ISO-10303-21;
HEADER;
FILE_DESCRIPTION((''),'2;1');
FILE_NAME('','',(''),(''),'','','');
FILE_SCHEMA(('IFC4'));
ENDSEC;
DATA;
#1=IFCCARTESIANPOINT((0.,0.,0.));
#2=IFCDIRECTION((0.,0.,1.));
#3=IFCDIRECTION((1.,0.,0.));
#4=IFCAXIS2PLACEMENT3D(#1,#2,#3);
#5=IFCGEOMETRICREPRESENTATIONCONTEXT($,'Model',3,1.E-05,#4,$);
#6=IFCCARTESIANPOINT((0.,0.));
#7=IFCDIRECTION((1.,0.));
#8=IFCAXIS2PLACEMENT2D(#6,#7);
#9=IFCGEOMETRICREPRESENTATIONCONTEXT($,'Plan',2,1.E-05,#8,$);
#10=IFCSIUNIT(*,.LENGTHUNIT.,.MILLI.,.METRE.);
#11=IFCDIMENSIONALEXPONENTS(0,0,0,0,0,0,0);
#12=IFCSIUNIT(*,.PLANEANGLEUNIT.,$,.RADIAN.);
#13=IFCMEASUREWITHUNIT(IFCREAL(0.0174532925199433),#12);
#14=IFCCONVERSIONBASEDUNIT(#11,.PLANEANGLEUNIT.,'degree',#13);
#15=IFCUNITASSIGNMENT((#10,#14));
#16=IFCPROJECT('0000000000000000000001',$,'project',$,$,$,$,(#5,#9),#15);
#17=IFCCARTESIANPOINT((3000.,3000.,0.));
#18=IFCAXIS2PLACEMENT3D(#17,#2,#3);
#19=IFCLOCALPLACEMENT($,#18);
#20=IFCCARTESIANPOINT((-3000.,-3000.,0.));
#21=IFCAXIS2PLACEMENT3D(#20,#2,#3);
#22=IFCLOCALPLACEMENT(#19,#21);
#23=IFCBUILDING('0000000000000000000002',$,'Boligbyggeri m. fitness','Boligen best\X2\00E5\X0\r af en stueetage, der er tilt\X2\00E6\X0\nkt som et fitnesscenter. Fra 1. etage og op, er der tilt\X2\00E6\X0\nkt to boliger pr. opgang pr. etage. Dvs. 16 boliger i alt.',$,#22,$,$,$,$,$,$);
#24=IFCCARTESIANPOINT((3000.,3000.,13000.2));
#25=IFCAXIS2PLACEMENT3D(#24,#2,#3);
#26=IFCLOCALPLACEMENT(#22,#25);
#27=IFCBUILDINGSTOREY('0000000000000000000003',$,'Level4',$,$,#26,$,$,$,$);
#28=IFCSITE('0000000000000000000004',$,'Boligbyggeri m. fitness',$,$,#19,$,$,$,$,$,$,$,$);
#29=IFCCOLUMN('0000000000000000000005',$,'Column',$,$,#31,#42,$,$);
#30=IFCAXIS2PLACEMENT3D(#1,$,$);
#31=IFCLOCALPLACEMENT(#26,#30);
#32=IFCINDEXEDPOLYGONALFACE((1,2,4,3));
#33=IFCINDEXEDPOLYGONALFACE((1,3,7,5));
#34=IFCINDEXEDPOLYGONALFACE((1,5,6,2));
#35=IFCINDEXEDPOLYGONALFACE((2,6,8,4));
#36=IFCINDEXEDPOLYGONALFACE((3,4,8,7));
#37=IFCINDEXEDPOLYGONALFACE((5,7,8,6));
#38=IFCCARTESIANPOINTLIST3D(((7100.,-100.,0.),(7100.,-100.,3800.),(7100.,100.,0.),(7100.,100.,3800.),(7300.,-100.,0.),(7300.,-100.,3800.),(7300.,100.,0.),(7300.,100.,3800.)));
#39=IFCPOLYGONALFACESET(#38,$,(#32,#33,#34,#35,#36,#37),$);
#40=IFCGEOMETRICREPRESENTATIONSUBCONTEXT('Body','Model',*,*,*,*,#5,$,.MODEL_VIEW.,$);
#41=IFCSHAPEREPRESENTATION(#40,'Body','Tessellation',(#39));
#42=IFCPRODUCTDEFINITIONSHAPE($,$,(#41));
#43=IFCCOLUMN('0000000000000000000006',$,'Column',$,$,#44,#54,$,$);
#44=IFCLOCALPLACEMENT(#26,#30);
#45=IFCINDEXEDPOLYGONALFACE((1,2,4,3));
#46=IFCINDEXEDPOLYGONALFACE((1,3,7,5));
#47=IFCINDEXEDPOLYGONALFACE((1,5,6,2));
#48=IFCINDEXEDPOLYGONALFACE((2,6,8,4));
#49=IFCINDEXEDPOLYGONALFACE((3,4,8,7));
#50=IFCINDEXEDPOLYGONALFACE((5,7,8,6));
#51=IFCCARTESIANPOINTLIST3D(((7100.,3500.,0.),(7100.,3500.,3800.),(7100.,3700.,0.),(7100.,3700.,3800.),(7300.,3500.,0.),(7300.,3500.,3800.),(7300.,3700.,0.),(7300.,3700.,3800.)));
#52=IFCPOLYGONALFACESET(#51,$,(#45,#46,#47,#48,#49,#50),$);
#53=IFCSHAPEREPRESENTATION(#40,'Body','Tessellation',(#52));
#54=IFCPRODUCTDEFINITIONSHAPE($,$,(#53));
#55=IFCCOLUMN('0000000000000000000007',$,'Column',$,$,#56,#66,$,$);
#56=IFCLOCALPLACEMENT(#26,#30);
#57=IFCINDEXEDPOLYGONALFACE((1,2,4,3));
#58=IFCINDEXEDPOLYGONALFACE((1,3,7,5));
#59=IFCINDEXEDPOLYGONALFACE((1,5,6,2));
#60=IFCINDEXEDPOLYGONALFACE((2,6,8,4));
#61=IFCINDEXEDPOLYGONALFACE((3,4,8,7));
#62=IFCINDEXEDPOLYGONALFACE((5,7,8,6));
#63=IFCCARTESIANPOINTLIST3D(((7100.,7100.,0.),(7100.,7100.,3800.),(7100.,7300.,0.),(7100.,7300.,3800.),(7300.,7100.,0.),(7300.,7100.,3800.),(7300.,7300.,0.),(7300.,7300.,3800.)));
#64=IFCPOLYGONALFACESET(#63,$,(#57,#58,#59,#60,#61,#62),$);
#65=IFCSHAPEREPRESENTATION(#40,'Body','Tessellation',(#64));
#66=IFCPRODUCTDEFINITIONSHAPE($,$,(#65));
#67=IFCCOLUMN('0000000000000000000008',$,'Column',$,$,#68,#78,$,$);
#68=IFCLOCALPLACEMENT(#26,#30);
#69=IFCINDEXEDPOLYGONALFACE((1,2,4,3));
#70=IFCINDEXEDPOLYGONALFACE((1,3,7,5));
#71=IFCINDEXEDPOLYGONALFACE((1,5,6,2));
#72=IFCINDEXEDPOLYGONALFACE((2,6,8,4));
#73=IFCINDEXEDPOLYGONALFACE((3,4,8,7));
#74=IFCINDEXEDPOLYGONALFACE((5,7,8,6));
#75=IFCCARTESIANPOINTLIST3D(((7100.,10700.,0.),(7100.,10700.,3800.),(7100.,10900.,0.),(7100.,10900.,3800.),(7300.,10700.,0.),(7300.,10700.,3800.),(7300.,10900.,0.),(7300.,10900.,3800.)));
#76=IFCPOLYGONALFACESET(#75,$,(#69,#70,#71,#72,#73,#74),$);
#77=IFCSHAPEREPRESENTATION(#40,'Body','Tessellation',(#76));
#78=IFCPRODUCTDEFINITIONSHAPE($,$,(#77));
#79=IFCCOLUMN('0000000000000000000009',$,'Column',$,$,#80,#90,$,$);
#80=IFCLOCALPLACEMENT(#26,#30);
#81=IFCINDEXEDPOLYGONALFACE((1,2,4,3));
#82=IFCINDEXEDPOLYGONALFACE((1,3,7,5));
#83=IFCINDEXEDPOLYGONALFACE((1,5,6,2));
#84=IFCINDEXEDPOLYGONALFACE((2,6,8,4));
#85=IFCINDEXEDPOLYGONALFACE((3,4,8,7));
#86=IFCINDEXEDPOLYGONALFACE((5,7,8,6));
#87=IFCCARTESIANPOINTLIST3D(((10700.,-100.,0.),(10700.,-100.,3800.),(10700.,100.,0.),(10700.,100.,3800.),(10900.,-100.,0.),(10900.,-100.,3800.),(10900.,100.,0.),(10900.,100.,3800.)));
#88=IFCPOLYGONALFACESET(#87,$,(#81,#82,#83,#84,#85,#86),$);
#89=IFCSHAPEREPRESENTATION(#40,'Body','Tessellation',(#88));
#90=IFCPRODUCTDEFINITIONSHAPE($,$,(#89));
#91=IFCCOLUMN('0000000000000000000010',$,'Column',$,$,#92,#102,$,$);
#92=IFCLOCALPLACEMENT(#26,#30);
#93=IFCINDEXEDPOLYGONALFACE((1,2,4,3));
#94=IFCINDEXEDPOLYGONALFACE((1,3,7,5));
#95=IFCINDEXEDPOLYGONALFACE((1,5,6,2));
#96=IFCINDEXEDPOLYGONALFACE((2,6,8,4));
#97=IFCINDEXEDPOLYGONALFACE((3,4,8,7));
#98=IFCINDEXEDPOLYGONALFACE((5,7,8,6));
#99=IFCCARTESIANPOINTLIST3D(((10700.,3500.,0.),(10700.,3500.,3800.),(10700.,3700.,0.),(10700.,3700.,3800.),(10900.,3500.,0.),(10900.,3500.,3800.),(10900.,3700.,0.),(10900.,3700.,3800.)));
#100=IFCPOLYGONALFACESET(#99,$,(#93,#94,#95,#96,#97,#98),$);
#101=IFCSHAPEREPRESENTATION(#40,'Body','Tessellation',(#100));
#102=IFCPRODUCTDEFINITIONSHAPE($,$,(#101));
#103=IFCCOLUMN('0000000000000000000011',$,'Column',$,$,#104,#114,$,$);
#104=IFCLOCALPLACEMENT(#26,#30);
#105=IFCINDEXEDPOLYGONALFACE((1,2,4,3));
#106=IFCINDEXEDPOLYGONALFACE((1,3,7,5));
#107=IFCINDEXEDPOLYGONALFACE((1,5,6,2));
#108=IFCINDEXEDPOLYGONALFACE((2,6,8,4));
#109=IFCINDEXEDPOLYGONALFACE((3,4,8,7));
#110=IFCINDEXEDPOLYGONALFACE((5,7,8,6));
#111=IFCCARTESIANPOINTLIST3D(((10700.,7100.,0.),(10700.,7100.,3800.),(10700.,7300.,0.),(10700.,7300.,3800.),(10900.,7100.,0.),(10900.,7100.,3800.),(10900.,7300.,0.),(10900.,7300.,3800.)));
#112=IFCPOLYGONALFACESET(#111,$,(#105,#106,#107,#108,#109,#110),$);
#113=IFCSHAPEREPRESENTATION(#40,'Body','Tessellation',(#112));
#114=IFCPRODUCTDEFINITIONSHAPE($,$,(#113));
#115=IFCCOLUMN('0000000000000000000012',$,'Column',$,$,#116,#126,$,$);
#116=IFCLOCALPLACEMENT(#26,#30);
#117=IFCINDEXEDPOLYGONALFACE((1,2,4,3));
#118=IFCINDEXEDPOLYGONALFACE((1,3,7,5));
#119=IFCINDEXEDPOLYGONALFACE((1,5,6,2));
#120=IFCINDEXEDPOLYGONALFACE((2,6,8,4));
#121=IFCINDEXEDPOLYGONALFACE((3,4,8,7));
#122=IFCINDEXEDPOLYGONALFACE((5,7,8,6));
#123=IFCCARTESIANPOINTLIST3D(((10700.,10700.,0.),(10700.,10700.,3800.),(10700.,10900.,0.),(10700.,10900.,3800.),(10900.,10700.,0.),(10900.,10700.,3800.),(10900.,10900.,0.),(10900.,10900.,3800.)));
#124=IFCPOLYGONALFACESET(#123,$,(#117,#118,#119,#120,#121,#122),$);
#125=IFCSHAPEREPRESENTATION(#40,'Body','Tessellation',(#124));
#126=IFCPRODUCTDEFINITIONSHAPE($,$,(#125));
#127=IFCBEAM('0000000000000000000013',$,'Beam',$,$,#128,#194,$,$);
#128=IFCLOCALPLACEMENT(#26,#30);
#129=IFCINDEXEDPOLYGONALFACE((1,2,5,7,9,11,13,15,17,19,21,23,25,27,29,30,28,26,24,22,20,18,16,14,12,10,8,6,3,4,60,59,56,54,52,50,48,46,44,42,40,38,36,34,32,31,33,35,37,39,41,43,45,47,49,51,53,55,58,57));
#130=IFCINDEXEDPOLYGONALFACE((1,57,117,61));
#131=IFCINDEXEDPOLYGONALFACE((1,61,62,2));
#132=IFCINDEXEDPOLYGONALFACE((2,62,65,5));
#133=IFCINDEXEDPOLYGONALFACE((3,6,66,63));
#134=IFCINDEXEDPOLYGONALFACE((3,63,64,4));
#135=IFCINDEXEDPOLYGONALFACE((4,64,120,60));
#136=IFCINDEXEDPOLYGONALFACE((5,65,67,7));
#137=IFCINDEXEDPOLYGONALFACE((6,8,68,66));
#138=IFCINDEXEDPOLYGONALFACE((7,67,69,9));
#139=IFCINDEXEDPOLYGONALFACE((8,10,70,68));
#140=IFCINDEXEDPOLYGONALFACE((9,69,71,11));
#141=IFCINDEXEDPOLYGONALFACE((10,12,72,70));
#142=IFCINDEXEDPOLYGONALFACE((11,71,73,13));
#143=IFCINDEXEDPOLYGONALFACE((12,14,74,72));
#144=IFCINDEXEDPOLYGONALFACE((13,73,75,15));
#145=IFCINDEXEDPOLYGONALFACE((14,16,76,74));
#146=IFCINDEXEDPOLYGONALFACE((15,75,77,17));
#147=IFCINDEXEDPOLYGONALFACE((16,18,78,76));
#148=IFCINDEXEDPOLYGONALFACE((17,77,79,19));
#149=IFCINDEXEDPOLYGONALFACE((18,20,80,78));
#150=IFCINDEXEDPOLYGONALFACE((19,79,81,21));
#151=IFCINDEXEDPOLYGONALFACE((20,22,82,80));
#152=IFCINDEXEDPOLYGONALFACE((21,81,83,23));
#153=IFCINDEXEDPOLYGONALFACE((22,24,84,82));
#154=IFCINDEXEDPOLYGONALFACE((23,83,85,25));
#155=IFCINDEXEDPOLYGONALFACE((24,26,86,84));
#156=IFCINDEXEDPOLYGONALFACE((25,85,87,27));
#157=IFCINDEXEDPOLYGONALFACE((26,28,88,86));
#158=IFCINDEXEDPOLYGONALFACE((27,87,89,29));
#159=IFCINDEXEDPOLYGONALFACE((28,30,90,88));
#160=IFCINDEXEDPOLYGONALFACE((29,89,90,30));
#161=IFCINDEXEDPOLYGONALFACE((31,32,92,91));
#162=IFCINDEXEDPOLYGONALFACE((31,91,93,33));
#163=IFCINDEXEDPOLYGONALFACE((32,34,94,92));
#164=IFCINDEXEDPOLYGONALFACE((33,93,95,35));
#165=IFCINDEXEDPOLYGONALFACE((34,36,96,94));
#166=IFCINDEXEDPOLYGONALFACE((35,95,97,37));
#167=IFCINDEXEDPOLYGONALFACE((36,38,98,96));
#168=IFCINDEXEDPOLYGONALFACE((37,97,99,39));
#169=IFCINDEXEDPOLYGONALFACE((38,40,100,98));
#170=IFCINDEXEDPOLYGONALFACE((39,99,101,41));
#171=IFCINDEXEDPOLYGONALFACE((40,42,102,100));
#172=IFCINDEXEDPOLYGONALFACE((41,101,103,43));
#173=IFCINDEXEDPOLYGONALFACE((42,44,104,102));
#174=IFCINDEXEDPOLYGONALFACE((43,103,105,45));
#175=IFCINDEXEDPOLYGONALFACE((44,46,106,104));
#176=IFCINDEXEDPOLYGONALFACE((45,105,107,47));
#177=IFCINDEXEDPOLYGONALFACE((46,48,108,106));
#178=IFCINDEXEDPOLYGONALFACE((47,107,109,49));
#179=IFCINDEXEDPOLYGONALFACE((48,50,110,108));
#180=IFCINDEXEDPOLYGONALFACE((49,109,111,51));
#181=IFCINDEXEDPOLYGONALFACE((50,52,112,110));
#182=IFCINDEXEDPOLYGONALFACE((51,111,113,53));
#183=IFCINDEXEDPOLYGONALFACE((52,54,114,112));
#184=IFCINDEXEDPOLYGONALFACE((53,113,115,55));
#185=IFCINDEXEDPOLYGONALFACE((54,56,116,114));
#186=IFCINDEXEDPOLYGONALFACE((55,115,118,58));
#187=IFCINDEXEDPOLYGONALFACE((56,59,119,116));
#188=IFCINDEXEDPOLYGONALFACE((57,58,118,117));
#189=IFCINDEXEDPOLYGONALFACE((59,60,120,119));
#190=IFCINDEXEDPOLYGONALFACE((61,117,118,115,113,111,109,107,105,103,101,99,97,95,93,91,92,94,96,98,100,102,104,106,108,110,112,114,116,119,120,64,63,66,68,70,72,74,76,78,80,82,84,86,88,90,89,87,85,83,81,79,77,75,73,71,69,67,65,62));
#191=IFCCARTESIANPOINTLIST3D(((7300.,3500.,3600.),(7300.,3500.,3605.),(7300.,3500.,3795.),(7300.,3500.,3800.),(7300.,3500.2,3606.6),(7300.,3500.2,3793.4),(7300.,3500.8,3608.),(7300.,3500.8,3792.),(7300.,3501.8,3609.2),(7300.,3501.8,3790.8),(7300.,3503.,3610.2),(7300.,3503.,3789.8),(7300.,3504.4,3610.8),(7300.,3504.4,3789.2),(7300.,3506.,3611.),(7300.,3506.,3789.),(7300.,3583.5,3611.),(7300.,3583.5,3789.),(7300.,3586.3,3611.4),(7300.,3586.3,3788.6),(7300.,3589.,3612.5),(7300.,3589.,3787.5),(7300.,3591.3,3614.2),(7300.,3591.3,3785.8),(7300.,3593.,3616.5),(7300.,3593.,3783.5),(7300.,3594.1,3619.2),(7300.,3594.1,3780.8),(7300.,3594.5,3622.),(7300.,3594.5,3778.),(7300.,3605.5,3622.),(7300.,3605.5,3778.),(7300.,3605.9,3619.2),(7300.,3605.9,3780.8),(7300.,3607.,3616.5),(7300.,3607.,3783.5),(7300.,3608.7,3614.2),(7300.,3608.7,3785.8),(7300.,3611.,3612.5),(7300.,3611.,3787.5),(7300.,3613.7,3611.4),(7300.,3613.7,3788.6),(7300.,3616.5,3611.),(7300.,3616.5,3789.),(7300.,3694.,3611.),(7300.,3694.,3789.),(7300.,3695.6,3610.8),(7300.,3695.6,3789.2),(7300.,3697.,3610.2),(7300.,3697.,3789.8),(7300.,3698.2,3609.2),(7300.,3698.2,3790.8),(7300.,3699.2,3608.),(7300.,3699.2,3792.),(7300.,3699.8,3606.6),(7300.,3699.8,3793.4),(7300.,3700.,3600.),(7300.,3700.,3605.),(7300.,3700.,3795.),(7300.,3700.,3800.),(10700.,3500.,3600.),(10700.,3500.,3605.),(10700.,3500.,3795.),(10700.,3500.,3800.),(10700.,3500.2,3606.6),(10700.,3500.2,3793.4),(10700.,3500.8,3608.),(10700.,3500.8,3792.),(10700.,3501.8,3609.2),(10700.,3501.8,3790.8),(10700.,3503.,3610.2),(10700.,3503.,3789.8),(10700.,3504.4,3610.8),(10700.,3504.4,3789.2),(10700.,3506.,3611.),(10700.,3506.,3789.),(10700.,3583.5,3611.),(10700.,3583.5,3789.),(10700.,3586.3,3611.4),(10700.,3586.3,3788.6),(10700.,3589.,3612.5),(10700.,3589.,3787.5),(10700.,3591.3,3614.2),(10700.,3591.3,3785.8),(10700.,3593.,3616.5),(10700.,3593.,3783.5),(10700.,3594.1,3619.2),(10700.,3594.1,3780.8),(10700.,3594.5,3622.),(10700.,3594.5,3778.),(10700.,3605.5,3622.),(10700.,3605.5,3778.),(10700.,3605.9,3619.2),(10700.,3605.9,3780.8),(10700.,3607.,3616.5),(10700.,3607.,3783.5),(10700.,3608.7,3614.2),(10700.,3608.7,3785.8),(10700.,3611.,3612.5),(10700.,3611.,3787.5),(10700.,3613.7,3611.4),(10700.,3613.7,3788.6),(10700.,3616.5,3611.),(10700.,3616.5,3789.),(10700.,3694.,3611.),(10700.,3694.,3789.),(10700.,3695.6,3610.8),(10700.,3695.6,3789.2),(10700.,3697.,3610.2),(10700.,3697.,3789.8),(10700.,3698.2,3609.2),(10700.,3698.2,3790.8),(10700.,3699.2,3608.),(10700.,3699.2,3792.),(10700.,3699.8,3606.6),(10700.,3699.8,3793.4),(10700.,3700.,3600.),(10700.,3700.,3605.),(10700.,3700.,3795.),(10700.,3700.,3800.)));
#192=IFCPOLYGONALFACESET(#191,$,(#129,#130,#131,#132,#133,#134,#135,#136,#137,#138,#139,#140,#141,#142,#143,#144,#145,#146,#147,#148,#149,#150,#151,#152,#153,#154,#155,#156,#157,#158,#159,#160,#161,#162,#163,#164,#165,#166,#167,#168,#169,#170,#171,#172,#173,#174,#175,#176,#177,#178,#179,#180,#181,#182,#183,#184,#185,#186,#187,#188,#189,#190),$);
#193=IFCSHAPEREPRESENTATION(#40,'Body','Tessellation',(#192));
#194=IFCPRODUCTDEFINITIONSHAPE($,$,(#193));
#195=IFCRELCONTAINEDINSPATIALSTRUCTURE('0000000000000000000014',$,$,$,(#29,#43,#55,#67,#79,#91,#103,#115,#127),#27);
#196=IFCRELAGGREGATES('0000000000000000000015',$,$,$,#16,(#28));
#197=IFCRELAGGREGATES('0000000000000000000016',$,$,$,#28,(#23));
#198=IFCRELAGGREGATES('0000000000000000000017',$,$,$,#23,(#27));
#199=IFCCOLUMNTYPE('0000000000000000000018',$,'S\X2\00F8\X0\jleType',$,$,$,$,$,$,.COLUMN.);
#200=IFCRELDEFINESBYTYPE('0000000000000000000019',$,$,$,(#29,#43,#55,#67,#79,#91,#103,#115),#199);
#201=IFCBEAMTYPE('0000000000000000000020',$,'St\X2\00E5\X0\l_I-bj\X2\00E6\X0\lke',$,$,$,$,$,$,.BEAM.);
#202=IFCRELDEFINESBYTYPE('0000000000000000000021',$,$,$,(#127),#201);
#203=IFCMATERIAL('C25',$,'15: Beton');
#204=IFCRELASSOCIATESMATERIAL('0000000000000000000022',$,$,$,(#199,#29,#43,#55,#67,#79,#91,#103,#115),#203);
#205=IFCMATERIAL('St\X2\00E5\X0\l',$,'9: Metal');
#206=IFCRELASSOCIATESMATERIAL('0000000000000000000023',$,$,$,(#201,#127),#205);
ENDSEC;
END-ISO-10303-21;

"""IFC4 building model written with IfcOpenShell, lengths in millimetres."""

from ifc_helpers import new_model, entity, si_unit, converted_unit, frame, origin_with_axes, origin_2d_with_axis, place, context, subcontext, project, spatial, rectangle, i_section, extrude, material, material_profile, profile_set, profile_usage, type_object, element, save


model = new_model("IFC4")

# Units and contexts
model_context = context("Model", 3, precision=1e-05, world=origin_with_axes())
plan_context = context("Plan", 2, precision=1e-05, world=origin_2d_with_axis())
body_context = subcontext(model_context, "Body", "Model", "MODEL_VIEW")
ifc_project = project(units=[si_unit("LENGTHUNIT", "METRE", prefix="MILLI"), converted_unit("PLANEANGLEUNIT", "degree", entity("IfcReal", 0.0174532925199433), si_unit("PLANEANGLEUNIT", "RADIAN"), dimensions=[0, 0, 0, 0, 0, 0, 0])], contexts=[model_context, plan_context])

# Site, building, storey
site_placement = place(None, frame((3000.0, 3000.0, 0.0), z_axis=(0.0, 0.0, 1.0), x_axis=(1.0, 0.0, 0.0)))
site = spatial("IfcSite", under=ifc_project, at=site_placement, Name="Boligbyggeri m. fitness")
building_placement = place(site_placement, frame((-3000.0, -3000.0, 0.0), z_axis=(0.0, 0.0, 1.0), x_axis=(1.0, 0.0, 0.0)))
building = spatial("IfcBuilding", under=site, at=building_placement, Name="Boligbyggeri m. fitness", Description="Boligen består af en stueetage, der er tiltænkt som et fitnesscenter. Fra 1. etage og op, er der tiltænkt to boliger pr. opgang pr. etage. Dvs. 16 boliger i alt.")
storey_placement = place(building_placement, frame((3000.0, 3000.0, 13000.2), z_axis=(0.0, 0.0, 1.0), x_axis=(1.0, 0.0, 0.0)))
storey = spatial("IfcBuildingStorey", under=building, at=storey_placement, Name="Level4")

# Columns
ifc_material_1 = material(Name="C25", Category="15: Beton")
ifc_material_profile_1 = material_profile(ifc_material_1, rectangle(XDim=200.0, YDim=200.0), Name="SøjleBeton", Category="15: Beton")
ifc_profile_set_1 = profile_set([ifc_material_profile_1], Name="200x200")
ifc_profile_usage_1 = profile_usage(ifc_profile_set_1, cardinal=5)
column_type = type_object("IfcColumnType", Name="SøjleType", PredefinedType="COLUMN", material=ifc_profile_set_1)
column_1_placement = place(storey_placement, frame((7200.0, 0.0, 0.0), z_axis=(0.0, 0.0, 1.0), x_axis=(1.0, 0.0, 0.0)))
element("IfcColumn", 1, at=column_1_placement, inside=storey, type_object=column_type, material=ifc_profile_usage_1, Name="Column", context=body_context, shape_type="SweptSolid", body=[
    extrude(rectangle(XDim=200.0, YDim=200.0), origin_with_axes(), (0.0, 0.0, 1.0), 3800.0),
])
ifc_profile_usage_2 = profile_usage(ifc_profile_set_1, cardinal=5)
column_2_placement = place(storey_placement, frame((7200.0, 3600.0, 0.0), z_axis=(0.0, 0.0, 1.0), x_axis=(1.0, 0.0, 0.0)))
element("IfcColumn", 2, at=column_2_placement, inside=storey, type_object=column_type, material=ifc_profile_usage_2, Name="Column", context=body_context, shape_type="SweptSolid", body=[
    extrude(rectangle(XDim=200.0, YDim=200.0), origin_with_axes(), (0.0, 0.0, 1.0), 3800.0),
])
ifc_profile_usage_3 = profile_usage(ifc_profile_set_1, cardinal=5)
column_3_placement = place(storey_placement, frame((7200.0, 7200.0, 0.0), z_axis=(0.0, 0.0, 1.0), x_axis=(1.0, 0.0, 0.0)))
element("IfcColumn", 3, at=column_3_placement, inside=storey, type_object=column_type, material=ifc_profile_usage_3, Name="Column", context=body_context, shape_type="SweptSolid", body=[
    extrude(rectangle(XDim=200.0, YDim=200.0), origin_with_axes(), (0.0, 0.0, 1.0), 3800.0),
])
ifc_profile_usage_4 = profile_usage(ifc_profile_set_1, cardinal=5)
column_4_placement = place(storey_placement, frame((7200.0, 10800.0, 0.0), z_axis=(0.0, 0.0, 1.0), x_axis=(1.0, 0.0, 0.0)))
element("IfcColumn", 4, at=column_4_placement, inside=storey, type_object=column_type, material=ifc_profile_usage_4, Name="Column", context=body_context, shape_type="SweptSolid", body=[
    extrude(rectangle(XDim=200.0, YDim=200.0), origin_with_axes(), (0.0, 0.0, 1.0), 3800.0),
])
ifc_profile_usage_5 = profile_usage(ifc_profile_set_1, cardinal=5)
column_5_placement = place(storey_placement, frame((10800.0, 0.0, 0.0), z_axis=(0.0, 0.0, 1.0), x_axis=(1.0, 0.0, 0.0)))
element("IfcColumn", 5, at=column_5_placement, inside=storey, type_object=column_type, material=ifc_profile_usage_5, Name="Column", context=body_context, shape_type="SweptSolid", body=[
    extrude(rectangle(XDim=200.0, YDim=200.0), origin_with_axes(), (0.0, 0.0, 1.0), 3800.0),
])
ifc_profile_usage_6 = profile_usage(ifc_profile_set_1, cardinal=5)
column_6_placement = place(storey_placement, frame((10800.0, 3600.0, 0.0), z_axis=(0.0, 0.0, 1.0), x_axis=(1.0, 0.0, 0.0)))
element("IfcColumn", 6, at=column_6_placement, inside=storey, type_object=column_type, material=ifc_profile_usage_6, Name="Column", context=body_context, shape_type="SweptSolid", body=[
    extrude(rectangle(XDim=200.0, YDim=200.0), origin_with_axes(), (0.0, 0.0, 1.0), 3800.0),
])
ifc_profile_usage_7 = profile_usage(ifc_profile_set_1, cardinal=5)
column_7_placement = place(storey_placement, frame((10800.0, 7200.0, 0.0), z_axis=(0.0, 0.0, 1.0), x_axis=(1.0, 0.0, 0.0)))
element("IfcColumn", 7, at=column_7_placement, inside=storey, type_object=column_type, material=ifc_profile_usage_7, Name="Column", context=body_context, shape_type="SweptSolid", body=[
    extrude(rectangle(XDim=200.0, YDim=200.0), origin_with_axes(), (0.0, 0.0, 1.0), 3800.0),
])
ifc_profile_usage_8 = profile_usage(ifc_profile_set_1, cardinal=5)
column_8_placement = place(storey_placement, frame((10800.0, 10800.0, 0.0), z_axis=(0.0, 0.0, 1.0), x_axis=(1.0, 0.0, 0.0)))
element("IfcColumn", 8, at=column_8_placement, inside=storey, type_object=column_type, material=ifc_profile_usage_8, Name="Column", context=body_context, shape_type="SweptSolid", body=[
    extrude(rectangle(XDim=200.0, YDim=200.0), origin_with_axes(), (0.0, 0.0, 1.0), 3800.0),
])

# Beam
ifc_material_2 = material(Name="Stål", Category="9: Metal")
ifc_material_profile_2 = material_profile(ifc_material_2, i_section(OverallWidth=200.0, OverallDepth=200.0, WebThickness=11.0, FlangeThickness=11.0, FilletRadius=11.0, FlangeEdgeRadius=6.0), Name="Stål", Category="9: Metal")
ifc_profile_set_2 = profile_set([ifc_material_profile_2], Name="NY_I-Profil")
ifc_profile_usage_9 = profile_usage(ifc_profile_set_2, cardinal=7)
beam_type = type_object("IfcBeamType", Name="Stål_I-bjælke", PredefinedType="BEAM", material=ifc_profile_set_2)
beam_1_placement = place(storey_placement, frame((7300.0, 3700.0, 3800.0), z_axis=(1.0, 0.0, 0.0), x_axis=(0.0, 1.0, 0.0)))
element("IfcBeam", 9, at=beam_1_placement, inside=storey, type_object=beam_type, material=ifc_profile_usage_9, Name="Beam", context=body_context, shape_type="SweptSolid", body=[
    extrude(i_section(OverallWidth=200.0, OverallDepth=200.0, WebThickness=11.0, FlangeThickness=11.0, FilletRadius=11.0, FlangeEdgeRadius=6.0), frame((-100.0, -100.0, 0.0), z_axis=(0.0, 0.0, 1.0), x_axis=(1.0, 0.0, 0.0)), (0.0, 0.0, 1.0), 3400.0),
])

save(model, "model.ifc")
